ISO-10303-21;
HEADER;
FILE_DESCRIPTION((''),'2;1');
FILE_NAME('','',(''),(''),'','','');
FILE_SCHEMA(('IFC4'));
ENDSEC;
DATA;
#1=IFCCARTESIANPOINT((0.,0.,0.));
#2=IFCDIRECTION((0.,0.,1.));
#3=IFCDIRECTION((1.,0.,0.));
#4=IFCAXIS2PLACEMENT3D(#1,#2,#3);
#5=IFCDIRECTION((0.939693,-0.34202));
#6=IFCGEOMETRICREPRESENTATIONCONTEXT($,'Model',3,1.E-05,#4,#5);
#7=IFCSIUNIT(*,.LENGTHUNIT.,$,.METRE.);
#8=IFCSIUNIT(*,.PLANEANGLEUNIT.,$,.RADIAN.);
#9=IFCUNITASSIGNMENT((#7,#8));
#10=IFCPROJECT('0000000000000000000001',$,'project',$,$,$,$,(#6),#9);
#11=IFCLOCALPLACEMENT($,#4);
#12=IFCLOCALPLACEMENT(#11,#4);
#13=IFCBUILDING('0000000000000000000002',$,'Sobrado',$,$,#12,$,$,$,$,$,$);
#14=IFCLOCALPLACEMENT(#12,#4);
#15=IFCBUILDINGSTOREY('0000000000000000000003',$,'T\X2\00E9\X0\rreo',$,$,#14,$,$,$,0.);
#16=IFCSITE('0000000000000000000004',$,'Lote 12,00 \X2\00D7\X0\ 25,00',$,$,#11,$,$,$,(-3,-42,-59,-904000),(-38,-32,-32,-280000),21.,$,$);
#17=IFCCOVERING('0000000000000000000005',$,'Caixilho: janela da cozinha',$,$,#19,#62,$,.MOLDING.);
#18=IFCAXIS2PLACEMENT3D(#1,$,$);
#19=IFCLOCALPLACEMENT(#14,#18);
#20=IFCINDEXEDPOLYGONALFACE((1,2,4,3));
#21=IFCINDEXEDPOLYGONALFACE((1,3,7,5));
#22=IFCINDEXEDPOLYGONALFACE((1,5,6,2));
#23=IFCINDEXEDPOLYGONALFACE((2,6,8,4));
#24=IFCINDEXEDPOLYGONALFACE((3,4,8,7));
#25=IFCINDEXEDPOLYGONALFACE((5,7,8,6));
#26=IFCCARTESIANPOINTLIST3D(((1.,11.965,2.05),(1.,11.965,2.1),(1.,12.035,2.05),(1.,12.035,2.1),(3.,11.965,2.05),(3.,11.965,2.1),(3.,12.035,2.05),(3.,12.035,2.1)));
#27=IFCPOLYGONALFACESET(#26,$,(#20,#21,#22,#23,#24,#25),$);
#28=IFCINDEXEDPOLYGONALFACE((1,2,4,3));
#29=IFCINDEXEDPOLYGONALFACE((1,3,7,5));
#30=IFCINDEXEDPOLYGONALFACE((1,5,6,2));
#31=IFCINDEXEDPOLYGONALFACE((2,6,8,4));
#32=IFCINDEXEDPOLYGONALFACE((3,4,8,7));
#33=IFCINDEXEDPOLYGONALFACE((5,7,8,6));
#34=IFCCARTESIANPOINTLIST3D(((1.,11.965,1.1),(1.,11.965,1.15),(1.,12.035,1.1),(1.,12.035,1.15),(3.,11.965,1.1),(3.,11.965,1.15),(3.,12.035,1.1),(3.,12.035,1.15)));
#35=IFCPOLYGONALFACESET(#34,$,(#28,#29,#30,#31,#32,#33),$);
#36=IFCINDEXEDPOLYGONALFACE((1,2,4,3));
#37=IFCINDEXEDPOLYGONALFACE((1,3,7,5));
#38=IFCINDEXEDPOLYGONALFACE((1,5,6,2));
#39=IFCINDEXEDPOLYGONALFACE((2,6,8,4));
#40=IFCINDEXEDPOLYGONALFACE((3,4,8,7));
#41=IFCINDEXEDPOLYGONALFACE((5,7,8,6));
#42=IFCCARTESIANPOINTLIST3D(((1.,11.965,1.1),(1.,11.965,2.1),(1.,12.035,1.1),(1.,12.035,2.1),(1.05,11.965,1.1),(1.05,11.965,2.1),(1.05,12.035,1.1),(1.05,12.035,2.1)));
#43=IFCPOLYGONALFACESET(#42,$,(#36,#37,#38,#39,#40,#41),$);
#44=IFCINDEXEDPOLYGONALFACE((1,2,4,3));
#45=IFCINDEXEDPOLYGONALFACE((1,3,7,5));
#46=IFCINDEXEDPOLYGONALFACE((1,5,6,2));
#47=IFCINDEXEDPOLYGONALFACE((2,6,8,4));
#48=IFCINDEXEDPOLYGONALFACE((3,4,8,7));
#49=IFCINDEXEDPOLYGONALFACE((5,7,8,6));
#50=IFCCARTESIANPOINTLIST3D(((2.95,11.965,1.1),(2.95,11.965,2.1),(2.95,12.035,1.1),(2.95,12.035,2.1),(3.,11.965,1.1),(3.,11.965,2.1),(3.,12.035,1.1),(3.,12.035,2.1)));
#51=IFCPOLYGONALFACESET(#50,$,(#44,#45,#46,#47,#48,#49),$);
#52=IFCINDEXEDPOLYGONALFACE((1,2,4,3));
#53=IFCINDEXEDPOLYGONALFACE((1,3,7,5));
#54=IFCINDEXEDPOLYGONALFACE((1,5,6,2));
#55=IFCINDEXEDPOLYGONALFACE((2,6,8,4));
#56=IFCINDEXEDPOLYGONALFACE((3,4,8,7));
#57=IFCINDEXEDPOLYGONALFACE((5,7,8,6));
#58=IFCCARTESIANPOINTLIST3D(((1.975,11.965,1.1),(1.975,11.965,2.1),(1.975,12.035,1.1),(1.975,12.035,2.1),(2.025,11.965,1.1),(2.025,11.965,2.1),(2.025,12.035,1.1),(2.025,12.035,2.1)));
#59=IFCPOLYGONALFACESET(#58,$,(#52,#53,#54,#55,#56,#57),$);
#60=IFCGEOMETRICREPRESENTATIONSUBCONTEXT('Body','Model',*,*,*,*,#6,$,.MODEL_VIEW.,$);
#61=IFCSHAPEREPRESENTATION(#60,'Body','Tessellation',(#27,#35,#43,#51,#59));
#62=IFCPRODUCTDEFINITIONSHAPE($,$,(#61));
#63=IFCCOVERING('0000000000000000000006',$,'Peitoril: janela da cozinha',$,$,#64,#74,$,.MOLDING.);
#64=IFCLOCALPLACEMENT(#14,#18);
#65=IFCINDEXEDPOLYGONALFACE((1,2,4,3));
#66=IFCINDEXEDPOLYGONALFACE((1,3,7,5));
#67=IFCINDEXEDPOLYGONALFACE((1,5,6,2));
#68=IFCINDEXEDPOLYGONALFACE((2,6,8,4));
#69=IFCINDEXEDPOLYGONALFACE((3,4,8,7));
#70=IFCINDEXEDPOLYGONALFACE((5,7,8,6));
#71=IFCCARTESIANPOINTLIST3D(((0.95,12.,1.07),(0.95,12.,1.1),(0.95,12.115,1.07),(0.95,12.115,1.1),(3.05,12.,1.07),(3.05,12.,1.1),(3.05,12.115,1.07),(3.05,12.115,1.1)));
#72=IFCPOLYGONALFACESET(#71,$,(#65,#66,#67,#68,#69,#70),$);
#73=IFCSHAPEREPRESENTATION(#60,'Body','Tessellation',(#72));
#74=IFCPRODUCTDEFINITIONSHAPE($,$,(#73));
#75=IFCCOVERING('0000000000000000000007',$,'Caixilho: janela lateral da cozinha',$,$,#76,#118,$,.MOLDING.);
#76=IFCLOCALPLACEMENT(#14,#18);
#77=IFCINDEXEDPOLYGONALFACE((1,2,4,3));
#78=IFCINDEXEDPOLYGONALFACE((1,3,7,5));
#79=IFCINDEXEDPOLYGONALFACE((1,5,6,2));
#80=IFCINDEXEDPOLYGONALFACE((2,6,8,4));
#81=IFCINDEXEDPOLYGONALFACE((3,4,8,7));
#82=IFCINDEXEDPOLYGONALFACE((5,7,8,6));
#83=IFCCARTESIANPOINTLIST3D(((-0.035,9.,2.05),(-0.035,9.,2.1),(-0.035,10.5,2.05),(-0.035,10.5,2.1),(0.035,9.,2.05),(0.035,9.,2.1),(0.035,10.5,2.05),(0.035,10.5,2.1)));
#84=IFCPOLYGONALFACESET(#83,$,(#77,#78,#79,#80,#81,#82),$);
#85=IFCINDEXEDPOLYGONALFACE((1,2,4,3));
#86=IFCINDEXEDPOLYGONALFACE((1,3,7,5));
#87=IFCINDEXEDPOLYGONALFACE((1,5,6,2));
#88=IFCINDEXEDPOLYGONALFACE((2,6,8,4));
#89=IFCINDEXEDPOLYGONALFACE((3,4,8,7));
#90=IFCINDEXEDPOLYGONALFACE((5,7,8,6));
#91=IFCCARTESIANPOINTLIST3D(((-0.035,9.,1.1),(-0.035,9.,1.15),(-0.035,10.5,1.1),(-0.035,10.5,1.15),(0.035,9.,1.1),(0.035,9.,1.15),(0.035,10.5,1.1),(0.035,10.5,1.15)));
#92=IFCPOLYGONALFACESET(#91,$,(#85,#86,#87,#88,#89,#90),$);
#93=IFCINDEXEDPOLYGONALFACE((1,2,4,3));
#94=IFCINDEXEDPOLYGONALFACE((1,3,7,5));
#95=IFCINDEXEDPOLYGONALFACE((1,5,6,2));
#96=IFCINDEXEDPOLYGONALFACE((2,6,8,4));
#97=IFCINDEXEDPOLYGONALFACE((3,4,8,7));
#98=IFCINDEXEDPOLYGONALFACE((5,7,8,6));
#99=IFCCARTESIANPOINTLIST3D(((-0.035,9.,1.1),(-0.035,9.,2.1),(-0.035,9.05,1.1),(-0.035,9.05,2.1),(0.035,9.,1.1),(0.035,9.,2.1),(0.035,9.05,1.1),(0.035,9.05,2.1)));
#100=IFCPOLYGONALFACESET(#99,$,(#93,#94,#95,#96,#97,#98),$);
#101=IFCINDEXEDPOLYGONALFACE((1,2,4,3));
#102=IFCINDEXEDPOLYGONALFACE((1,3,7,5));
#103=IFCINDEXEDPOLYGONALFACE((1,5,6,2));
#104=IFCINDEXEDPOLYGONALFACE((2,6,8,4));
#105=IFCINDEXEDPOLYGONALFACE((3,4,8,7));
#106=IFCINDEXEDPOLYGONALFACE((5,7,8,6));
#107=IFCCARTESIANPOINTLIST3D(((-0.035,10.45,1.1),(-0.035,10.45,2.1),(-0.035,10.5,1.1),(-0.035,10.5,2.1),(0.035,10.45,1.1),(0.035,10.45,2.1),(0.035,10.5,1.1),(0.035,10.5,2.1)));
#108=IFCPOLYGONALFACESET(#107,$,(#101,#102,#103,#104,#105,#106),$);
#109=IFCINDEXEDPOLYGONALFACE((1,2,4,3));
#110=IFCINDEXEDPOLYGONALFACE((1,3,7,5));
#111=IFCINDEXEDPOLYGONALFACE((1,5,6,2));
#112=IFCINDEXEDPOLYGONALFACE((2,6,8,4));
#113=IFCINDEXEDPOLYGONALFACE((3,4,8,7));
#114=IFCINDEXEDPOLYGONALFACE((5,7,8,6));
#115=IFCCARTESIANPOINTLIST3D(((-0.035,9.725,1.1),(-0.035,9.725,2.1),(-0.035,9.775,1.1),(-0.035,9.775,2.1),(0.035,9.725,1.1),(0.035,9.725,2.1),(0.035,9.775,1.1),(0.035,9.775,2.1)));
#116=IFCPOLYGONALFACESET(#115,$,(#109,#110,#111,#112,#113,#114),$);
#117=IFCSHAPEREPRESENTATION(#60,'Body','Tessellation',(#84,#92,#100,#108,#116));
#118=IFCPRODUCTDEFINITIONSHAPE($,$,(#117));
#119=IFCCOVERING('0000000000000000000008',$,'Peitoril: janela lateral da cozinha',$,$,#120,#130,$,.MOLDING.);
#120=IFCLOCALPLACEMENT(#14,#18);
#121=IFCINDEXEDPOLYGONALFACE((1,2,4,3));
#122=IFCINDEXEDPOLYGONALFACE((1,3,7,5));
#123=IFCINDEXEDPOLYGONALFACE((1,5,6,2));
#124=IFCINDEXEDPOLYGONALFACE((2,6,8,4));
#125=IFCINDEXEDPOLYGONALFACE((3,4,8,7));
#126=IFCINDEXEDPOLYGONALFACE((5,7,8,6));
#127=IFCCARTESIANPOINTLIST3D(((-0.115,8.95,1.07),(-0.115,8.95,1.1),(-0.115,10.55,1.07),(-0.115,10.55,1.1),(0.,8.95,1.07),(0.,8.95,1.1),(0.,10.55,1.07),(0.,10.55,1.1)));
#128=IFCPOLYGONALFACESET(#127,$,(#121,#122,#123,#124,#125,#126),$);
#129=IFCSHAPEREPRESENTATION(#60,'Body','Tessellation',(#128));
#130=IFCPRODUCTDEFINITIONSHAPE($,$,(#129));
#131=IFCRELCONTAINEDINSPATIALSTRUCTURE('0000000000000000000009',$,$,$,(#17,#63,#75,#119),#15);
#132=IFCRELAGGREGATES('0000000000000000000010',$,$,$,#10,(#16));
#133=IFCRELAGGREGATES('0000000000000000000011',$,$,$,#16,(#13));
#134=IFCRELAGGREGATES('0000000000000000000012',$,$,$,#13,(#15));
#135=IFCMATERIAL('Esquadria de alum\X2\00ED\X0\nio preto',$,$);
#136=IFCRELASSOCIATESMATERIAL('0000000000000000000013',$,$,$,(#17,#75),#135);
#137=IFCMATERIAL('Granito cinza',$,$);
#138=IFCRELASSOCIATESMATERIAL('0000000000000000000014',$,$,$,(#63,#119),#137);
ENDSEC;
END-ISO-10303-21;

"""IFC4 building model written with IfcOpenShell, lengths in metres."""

from ifc_helpers import new_model, si_unit, direction, frame, origin_with_axes, place, context, subcontext, project, spatial, line, indexed_curve, outline, extrude, material, element, save


model = new_model("IFC4")

# Units and contexts
model_context = context("Model", 3, precision=1e-05, world=origin_with_axes(), true_north=direction((0.939693, -0.34202)))
body_context = subcontext(model_context, "Body", "Model", "MODEL_VIEW")
ifc_project = project(units=[si_unit("LENGTHUNIT", "METRE"), si_unit("PLANEANGLEUNIT", "RADIAN")], contexts=[model_context])

# Site, building, storey
site_placement = place(None, origin_with_axes())
site = spatial("IfcSite", under=ifc_project, at=site_placement, Name="Lote 12,00 × 25,00", RefLatitude=(-3, -42, -59, -904000), RefLongitude=(-38, -32, -32, -280000), RefElevation=21.0)
building_placement = place(site_placement, origin_with_axes())
building = spatial("IfcBuilding", under=site, at=building_placement, Name="Sobrado")
storey_placement = place(building_placement, origin_with_axes())
storey = spatial("IfcBuildingStorey", under=building, at=storey_placement, Name="Térreo", Elevation=0.0)

# Coverings
ifc_material_1 = material(Name="Granito cinza")
ifc_material_2 = material(Name="Esquadria de alumínio preto")
covering_1_placement = place(storey_placement, origin_with_axes())
element("IfcCovering", 1, at=covering_1_placement, inside=storey, material=ifc_material_2, Name="Caixilho: janela da cozinha", PredefinedType="MOLDING", context=body_context, shape_type="SweptSolid", body=[
    extrude(outline(indexed_curve([(1.0, 11.965), (3.0, 11.965), (3.0, 12.035), (1.0, 12.035)], segments=[line(1, 2, 3, 4, 1)])), frame((0.0, 0.0, 2.05), z_axis=(0.0, 0.0, 1.0), x_axis=(1.0, 0.0, 0.0)), (0.0, 0.0, 1.0), 0.05),
    extrude(outline(indexed_curve([(1.0, 11.965), (3.0, 11.965), (3.0, 12.035), (1.0, 12.035)], segments=[line(1, 2, 3, 4, 1)])), frame((0.0, 0.0, 1.1), z_axis=(0.0, 0.0, 1.0), x_axis=(1.0, 0.0, 0.0)), (0.0, 0.0, 1.0), 0.05),
    extrude(outline(indexed_curve([(1.0, 11.965), (1.05, 11.965), (1.05, 12.035), (1.0, 12.035)], segments=[line(1, 2, 3, 4, 1)])), frame((0.0, 0.0, 1.1), z_axis=(0.0, 0.0, 1.0), x_axis=(1.0, 0.0, 0.0)), (0.0, 0.0, 1.0), 1.0),
    extrude(outline(indexed_curve([(2.95, 11.965), (3.0, 11.965), (3.0, 12.035), (2.95, 12.035)], segments=[line(1, 2, 3, 4, 1)])), frame((0.0, 0.0, 1.1), z_axis=(0.0, 0.0, 1.0), x_axis=(1.0, 0.0, 0.0)), (0.0, 0.0, 1.0), 1.0),
    extrude(outline(indexed_curve([(1.975, 11.965), (2.025, 11.965), (2.025, 12.035), (1.975, 12.035)], segments=[line(1, 2, 3, 4, 1)])), frame((0.0, 0.0, 1.1), z_axis=(0.0, 0.0, 1.0), x_axis=(1.0, 0.0, 0.0)), (0.0, 0.0, 1.0), 1.0),
])
covering_2_placement = place(storey_placement, origin_with_axes())
element("IfcCovering", 2, at=covering_2_placement, inside=storey, material=ifc_material_1, Name="Peitoril: janela da cozinha", PredefinedType="MOLDING", context=body_context, shape_type="SweptSolid", body=[
    extrude(outline(indexed_curve([(0.95, 12.0), (3.05, 12.0), (3.05, 12.115), (0.95, 12.115)], segments=[line(1, 2, 3, 4, 1)])), frame((0.0, 0.0, 1.07), z_axis=(0.0, 0.0, 1.0), x_axis=(1.0, 0.0, 0.0)), (0.0, 0.0, 1.0), 0.03),
])
covering_3_placement = place(storey_placement, origin_with_axes())
element("IfcCovering", 3, at=covering_3_placement, inside=storey, material=ifc_material_2, Name="Caixilho: janela lateral da cozinha", PredefinedType="MOLDING", context=body_context, shape_type="SweptSolid", body=[
    extrude(outline(indexed_curve([(-0.035, 9.0), (0.035, 9.0), (0.035, 10.5), (-0.035, 10.5)], segments=[line(1, 2, 3, 4, 1)])), frame((0.0, 0.0, 2.05), z_axis=(0.0, 0.0, 1.0), x_axis=(1.0, 0.0, 0.0)), (0.0, 0.0, 1.0), 0.05),
    extrude(outline(indexed_curve([(-0.035, 9.0), (0.035, 9.0), (0.035, 10.5), (-0.035, 10.5)], segments=[line(1, 2, 3, 4, 1)])), frame((0.0, 0.0, 1.1), z_axis=(0.0, 0.0, 1.0), x_axis=(1.0, 0.0, 0.0)), (0.0, 0.0, 1.0), 0.05),
    extrude(outline(indexed_curve([(-0.035, 9.0), (0.035, 9.0), (0.035, 9.05), (-0.035, 9.05)], segments=[line(1, 2, 3, 4, 1)])), frame((0.0, 0.0, 1.1), z_axis=(0.0, 0.0, 1.0), x_axis=(1.0, 0.0, 0.0)), (0.0, 0.0, 1.0), 1.0),
    extrude(outline(indexed_curve([(-0.035, 10.45), (0.035, 10.45), (0.035, 10.5), (-0.035, 10.5)], segments=[line(1, 2, 3, 4, 1)])), frame((0.0, 0.0, 1.1), z_axis=(0.0, 0.0, 1.0), x_axis=(1.0, 0.0, 0.0)), (0.0, 0.0, 1.0), 1.0),
    extrude(outline(indexed_curve([(-0.035, 9.725), (0.035, 9.725), (0.035, 9.775), (-0.035, 9.775)], segments=[line(1, 2, 3, 4, 1)])), frame((0.0, 0.0, 1.1), z_axis=(0.0, 0.0, 1.0), x_axis=(1.0, 0.0, 0.0)), (0.0, 0.0, 1.0), 1.0),
])
covering_4_placement = place(storey_placement, origin_with_axes())
element("IfcCovering", 4, at=covering_4_placement, inside=storey, material=ifc_material_1, Name="Peitoril: janela lateral da cozinha", PredefinedType="MOLDING", context=body_context, shape_type="SweptSolid", body=[
    extrude(outline(indexed_curve([(-0.115, 8.95), (0.0, 8.95), (0.0, 10.55), (-0.115, 10.55)], segments=[line(1, 2, 3, 4, 1)])), frame((0.0, 0.0, 1.07), z_axis=(0.0, 0.0, 1.0), x_axis=(1.0, 0.0, 0.0)), (0.0, 0.0, 1.0), 0.03),
])

save(model, "model.ifc")
